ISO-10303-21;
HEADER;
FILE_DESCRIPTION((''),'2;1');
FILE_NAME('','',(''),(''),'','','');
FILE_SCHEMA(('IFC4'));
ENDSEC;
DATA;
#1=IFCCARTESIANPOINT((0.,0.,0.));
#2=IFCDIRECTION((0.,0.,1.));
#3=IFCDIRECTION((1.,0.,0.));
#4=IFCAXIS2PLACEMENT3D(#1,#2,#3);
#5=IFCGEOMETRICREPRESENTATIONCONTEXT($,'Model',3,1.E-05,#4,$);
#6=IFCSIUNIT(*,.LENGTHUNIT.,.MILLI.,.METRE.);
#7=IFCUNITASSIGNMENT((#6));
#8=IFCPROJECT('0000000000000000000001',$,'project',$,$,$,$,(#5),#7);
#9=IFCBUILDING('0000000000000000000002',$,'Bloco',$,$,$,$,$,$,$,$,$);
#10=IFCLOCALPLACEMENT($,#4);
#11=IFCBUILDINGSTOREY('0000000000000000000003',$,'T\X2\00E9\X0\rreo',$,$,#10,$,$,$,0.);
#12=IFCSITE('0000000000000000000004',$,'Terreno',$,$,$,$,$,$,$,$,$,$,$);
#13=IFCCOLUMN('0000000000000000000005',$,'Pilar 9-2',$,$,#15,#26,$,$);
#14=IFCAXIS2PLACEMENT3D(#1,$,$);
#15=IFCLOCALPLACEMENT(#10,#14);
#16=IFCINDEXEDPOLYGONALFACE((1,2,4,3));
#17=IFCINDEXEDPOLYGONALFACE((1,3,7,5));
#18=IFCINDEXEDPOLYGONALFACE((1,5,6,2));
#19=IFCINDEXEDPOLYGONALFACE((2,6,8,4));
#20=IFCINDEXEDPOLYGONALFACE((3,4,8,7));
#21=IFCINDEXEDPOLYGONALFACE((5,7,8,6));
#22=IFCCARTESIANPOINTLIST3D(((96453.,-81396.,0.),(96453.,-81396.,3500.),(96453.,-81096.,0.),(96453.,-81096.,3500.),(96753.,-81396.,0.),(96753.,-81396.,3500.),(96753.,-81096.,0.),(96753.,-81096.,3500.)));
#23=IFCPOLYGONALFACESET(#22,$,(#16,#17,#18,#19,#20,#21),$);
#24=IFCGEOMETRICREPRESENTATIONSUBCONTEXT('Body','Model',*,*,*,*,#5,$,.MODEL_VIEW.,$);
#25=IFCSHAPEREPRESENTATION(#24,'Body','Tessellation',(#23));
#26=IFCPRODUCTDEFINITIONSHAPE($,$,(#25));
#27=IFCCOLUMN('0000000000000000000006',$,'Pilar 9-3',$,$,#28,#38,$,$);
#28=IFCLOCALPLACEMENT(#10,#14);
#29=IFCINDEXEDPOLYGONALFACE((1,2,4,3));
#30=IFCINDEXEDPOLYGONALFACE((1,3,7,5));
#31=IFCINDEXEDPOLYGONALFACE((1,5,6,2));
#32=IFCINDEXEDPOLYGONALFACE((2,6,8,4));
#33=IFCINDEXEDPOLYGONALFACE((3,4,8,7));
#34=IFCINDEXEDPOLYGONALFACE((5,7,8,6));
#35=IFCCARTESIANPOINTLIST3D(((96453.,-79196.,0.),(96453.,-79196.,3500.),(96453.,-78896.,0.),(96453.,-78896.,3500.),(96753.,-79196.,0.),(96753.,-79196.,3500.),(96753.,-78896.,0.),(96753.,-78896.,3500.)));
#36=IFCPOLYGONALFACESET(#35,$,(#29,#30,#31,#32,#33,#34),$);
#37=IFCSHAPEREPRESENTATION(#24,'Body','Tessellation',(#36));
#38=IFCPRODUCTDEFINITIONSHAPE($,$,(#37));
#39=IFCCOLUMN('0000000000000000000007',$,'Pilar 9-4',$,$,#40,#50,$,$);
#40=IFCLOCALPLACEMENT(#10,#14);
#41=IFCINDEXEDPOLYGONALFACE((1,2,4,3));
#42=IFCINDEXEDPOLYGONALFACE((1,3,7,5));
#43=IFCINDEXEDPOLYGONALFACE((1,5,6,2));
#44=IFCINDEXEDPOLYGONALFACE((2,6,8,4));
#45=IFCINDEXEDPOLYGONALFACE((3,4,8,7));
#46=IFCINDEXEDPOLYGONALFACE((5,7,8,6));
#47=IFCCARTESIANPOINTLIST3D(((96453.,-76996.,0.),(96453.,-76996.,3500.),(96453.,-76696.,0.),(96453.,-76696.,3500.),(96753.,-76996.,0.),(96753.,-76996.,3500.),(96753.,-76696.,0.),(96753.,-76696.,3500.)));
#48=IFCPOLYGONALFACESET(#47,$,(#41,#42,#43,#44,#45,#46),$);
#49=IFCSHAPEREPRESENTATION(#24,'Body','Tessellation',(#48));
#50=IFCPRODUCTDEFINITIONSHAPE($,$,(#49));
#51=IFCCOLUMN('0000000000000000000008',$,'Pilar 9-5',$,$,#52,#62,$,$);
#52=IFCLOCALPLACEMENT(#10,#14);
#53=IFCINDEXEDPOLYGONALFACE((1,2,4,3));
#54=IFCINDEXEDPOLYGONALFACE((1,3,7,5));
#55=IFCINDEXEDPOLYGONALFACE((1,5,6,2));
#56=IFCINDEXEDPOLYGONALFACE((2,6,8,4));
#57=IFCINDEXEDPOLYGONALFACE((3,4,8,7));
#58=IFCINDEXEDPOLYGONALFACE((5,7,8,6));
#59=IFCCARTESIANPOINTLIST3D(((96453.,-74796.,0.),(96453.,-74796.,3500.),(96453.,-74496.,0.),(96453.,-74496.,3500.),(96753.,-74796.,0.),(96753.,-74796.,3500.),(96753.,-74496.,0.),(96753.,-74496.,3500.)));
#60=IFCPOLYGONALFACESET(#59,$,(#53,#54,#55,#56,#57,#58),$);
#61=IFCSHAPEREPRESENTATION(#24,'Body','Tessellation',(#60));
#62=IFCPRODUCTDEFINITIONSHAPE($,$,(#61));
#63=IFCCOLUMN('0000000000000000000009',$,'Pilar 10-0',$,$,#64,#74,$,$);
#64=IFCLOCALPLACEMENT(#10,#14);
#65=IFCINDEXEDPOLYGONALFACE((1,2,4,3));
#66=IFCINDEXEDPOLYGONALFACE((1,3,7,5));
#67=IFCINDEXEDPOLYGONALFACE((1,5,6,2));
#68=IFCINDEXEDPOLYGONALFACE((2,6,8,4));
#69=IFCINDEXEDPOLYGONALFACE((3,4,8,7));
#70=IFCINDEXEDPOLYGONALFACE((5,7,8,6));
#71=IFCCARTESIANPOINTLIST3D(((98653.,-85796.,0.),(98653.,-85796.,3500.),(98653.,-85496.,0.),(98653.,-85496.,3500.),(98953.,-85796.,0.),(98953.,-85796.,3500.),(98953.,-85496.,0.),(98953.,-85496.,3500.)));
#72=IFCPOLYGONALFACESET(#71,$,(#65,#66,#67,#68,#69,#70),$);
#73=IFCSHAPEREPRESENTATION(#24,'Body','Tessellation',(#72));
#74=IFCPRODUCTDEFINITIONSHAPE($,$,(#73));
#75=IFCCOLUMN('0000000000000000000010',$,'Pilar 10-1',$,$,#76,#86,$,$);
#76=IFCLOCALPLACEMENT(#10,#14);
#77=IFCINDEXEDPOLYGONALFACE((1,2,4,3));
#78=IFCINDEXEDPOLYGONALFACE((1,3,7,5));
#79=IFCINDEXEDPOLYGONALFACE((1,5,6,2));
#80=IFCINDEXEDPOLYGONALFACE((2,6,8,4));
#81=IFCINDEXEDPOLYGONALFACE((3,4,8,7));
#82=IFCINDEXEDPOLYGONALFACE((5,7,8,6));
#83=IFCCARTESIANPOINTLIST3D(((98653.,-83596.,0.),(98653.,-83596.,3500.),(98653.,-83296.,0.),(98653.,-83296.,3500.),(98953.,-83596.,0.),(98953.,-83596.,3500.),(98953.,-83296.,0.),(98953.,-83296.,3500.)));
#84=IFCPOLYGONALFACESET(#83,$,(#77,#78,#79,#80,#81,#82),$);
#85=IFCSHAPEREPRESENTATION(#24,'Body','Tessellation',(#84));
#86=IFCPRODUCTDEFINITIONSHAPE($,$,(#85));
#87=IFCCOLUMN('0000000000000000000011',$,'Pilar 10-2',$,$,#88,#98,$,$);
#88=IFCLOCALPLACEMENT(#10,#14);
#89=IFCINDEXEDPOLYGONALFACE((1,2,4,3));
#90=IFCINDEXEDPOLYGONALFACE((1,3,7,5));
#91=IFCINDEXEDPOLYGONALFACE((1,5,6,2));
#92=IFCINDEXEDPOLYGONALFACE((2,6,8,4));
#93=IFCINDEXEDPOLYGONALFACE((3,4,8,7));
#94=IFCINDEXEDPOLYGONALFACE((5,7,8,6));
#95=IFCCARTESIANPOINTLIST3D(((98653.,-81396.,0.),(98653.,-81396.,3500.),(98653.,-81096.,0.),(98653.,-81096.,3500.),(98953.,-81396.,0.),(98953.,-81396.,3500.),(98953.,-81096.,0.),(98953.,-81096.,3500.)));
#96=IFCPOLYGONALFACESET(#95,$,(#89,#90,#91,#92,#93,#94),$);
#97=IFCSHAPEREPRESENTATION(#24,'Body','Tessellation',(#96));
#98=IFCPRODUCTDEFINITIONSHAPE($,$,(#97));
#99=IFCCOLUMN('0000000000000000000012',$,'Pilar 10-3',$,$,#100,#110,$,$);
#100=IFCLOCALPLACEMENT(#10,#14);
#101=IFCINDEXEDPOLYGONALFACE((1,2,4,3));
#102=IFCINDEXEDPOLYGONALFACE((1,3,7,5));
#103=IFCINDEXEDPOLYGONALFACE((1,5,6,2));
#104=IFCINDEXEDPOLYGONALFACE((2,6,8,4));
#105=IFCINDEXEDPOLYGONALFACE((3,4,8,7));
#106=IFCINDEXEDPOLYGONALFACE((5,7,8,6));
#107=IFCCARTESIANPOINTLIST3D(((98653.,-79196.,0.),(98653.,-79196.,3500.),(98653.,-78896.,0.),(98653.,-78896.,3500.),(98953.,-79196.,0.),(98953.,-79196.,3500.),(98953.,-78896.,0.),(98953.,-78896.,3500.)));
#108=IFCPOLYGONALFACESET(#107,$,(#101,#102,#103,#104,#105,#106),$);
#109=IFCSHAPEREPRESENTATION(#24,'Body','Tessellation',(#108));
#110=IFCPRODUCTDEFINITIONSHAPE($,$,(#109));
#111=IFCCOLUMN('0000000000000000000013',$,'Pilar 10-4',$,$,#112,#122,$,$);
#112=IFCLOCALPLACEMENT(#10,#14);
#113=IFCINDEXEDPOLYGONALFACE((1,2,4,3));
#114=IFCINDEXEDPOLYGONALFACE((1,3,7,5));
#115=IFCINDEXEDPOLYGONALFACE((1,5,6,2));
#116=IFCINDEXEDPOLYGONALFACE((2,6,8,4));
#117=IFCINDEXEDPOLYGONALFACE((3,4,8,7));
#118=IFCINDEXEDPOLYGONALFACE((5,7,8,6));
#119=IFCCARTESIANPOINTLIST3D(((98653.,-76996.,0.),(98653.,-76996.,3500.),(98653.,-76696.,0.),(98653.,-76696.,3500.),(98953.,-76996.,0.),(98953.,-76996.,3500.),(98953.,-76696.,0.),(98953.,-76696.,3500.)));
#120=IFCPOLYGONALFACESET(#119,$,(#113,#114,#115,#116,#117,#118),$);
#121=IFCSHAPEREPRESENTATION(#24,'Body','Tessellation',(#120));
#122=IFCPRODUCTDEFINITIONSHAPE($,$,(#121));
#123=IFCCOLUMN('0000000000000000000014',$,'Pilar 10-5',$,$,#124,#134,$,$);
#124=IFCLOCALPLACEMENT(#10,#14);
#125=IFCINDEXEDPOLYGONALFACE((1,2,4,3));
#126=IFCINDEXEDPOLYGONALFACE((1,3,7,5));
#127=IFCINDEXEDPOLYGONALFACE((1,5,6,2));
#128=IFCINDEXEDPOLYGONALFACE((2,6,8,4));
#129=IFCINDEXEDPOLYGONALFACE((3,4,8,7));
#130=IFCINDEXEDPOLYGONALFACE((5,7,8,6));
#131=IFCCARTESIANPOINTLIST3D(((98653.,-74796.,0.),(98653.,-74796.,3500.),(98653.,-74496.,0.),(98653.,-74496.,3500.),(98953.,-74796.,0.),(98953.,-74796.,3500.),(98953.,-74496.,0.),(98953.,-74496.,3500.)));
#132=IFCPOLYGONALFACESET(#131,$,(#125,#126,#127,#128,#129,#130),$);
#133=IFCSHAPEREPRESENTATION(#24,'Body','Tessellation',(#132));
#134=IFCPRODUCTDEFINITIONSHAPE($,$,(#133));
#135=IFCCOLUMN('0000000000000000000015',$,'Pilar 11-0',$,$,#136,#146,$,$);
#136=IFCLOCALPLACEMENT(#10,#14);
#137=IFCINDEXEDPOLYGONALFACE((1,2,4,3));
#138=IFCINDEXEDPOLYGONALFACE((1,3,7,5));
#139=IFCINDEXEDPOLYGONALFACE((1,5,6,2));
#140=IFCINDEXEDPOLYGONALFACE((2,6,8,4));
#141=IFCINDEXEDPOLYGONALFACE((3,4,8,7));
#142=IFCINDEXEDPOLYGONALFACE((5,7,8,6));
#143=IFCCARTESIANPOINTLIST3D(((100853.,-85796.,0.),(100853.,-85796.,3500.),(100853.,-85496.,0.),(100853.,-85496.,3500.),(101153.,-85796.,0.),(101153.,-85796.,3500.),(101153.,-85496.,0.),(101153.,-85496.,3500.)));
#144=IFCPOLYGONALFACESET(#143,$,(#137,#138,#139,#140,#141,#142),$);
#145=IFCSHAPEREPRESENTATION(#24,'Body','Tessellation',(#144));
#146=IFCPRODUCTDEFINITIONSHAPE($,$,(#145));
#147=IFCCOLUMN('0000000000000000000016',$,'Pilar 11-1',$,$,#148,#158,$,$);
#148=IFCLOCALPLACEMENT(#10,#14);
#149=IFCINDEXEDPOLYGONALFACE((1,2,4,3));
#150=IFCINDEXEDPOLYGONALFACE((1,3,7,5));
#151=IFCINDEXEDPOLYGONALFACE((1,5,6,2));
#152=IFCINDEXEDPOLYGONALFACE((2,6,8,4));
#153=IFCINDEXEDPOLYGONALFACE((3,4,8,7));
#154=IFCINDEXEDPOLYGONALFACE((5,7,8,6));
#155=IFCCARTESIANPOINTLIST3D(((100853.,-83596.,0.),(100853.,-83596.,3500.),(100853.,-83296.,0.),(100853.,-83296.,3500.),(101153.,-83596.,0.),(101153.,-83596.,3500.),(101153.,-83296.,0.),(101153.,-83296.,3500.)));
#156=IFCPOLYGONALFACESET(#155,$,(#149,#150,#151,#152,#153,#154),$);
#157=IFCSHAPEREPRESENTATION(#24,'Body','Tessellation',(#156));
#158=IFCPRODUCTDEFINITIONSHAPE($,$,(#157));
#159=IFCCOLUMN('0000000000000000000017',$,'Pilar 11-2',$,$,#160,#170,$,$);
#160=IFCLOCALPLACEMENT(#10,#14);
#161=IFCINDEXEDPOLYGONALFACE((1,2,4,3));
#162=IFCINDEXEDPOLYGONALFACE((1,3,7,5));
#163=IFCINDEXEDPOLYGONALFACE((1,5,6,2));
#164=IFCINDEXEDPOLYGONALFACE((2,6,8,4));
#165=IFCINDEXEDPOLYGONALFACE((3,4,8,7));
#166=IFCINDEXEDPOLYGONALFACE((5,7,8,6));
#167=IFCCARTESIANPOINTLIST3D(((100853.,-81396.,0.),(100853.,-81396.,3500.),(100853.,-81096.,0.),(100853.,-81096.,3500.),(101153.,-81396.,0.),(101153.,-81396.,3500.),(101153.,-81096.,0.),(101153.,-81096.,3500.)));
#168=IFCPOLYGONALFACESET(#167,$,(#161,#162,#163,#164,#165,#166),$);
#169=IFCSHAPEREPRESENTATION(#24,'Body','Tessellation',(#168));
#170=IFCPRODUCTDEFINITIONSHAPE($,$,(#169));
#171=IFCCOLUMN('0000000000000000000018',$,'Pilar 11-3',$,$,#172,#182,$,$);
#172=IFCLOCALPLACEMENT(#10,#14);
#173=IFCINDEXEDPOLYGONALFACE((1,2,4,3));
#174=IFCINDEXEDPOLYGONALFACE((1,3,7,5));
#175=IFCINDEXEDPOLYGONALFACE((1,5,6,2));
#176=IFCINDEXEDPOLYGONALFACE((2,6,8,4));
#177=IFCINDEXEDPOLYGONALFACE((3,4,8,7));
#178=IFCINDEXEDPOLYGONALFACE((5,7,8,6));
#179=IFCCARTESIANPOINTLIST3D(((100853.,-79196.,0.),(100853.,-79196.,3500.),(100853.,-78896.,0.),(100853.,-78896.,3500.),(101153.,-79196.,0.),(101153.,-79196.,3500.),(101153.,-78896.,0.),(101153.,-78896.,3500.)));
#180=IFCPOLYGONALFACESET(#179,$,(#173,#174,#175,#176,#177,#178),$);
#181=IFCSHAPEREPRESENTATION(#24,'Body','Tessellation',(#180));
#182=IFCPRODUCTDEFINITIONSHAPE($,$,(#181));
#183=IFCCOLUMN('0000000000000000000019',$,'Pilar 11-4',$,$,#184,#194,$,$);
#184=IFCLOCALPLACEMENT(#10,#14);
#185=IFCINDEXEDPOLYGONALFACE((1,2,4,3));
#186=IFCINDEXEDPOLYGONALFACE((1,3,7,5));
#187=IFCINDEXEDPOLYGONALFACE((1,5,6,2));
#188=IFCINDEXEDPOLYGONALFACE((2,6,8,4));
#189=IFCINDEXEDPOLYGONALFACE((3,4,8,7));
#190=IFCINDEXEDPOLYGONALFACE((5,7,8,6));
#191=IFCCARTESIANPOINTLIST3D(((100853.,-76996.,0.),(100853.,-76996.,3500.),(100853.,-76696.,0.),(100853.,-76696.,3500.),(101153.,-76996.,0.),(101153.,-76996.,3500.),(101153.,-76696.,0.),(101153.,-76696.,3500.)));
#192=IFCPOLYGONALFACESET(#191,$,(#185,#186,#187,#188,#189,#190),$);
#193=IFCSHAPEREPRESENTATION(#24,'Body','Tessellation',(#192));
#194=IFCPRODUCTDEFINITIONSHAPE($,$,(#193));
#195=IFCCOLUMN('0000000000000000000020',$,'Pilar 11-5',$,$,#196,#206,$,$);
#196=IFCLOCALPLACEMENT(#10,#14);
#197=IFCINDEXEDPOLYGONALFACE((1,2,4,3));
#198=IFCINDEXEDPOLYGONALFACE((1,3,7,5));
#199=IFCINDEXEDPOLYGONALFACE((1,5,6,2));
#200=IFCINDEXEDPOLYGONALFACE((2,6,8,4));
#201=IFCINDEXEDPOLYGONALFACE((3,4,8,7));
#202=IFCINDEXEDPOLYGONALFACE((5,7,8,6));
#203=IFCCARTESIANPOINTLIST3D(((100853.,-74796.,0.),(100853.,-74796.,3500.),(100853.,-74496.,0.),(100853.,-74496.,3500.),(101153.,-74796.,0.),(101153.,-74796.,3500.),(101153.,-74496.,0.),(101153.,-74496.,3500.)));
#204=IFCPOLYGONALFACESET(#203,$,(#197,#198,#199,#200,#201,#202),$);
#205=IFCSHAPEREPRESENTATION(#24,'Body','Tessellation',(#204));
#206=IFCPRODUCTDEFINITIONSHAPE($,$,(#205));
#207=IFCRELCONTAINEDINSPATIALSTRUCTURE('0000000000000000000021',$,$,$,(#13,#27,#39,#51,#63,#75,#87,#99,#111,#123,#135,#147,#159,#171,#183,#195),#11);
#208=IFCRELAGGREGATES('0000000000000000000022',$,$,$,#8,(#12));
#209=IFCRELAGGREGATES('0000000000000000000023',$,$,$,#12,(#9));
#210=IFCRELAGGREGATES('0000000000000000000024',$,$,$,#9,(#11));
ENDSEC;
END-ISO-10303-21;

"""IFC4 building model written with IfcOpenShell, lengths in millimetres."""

from ifc_helpers import new_model, si_unit, origin, origin_with_axes, place, context, subcontext, project, spatial, polyline, outline, extrude, element, save


model = new_model("IFC4")

# Units and contexts
model_context = context("Model", 3, precision=1e-05, world=origin_with_axes())
body_context = subcontext(model_context, "Body", "Model", "MODEL_VIEW")
ifc_project = project(units=[si_unit("LENGTHUNIT", "METRE", prefix="MILLI")], contexts=[model_context])

# Site, building, storey
site = spatial("IfcSite", under=ifc_project, Name="Terreno")
building = spatial("IfcBuilding", under=site, Name="Bloco")
storey_placement = place(None, origin_with_axes())
storey = spatial("IfcBuildingStorey", under=building, at=storey_placement, Name="Térreo", Elevation=0.0)

# Columns
column_1_placement = place(storey_placement, origin_with_axes())
element("IfcColumn", 1, at=column_1_placement, inside=storey, Name="Pilar 9-2", context=body_context, shape_type="SweptSolid", body=[
    extrude(outline(polyline([(96453.0, -81396.0), (96753.0, -81396.0), (96753.0, -81096.0), (96453.0, -81096.0), (96453.0, -81396.0)])), origin(), (0.0, 0.0, 1.0), 3500.0),
])
column_2_placement = place(storey_placement, origin_with_axes())
element("IfcColumn", 2, at=column_2_placement, inside=storey, Name="Pilar 9-3", context=body_context, shape_type="SweptSolid", body=[
    extrude(outline(polyline([(96453.0, -79196.0), (96753.0, -79196.0), (96753.0, -78896.0), (96453.0, -78896.0), (96453.0, -79196.0)])), origin(), (0.0, 0.0, 1.0), 3500.0),
])
column_3_placement = place(storey_placement, origin_with_axes())
element("IfcColumn", 3, at=column_3_placement, inside=storey, Name="Pilar 9-4", context=body_context, shape_type="SweptSolid", body=[
    extrude(outline(polyline([(96453.0, -76996.0), (96753.0, -76996.0), (96753.0, -76696.0), (96453.0, -76696.0), (96453.0, -76996.0)])), origin(), (0.0, 0.0, 1.0), 3500.0),
])
column_4_placement = place(storey_placement, origin_with_axes())
element("IfcColumn", 4, at=column_4_placement, inside=storey, Name="Pilar 9-5", context=body_context, shape_type="SweptSolid", body=[
    extrude(outline(polyline([(96453.0, -74796.0), (96753.0, -74796.0), (96753.0, -74496.0), (96453.0, -74496.0), (96453.0, -74796.0)])), origin(), (0.0, 0.0, 1.0), 3500.0),
])
column_5_placement = place(storey_placement, origin_with_axes())
element("IfcColumn", 5, at=column_5_placement, inside=storey, Name="Pilar 10-0", context=body_context, shape_type="SweptSolid", body=[
    extrude(outline(polyline([(98653.0, -85796.0), (98953.0, -85796.0), (98953.0, -85496.0), (98653.0, -85496.0), (98653.0, -85796.0)])), origin(), (0.0, 0.0, 1.0), 3500.0),
])
column_6_placement = place(storey_placement, origin_with_axes())
element("IfcColumn", 6, at=column_6_placement, inside=storey, Name="Pilar 10-1", context=body_context, shape_type="SweptSolid", body=[
    extrude(outline(polyline([(98653.0, -83596.0), (98953.0, -83596.0), (98953.0, -83296.0), (98653.0, -83296.0), (98653.0, -83596.0)])), origin(), (0.0, 0.0, 1.0), 3500.0),
])
column_7_placement = place(storey_placement, origin_with_axes())
element("IfcColumn", 7, at=column_7_placement, inside=storey, Name="Pilar 10-2", context=body_context, shape_type="SweptSolid", body=[
    extrude(outline(polyline([(98653.0, -81396.0), (98953.0, -81396.0), (98953.0, -81096.0), (98653.0, -81096.0), (98653.0, -81396.0)])), origin(), (0.0, 0.0, 1.0), 3500.0),
])
column_8_placement = place(storey_placement, origin_with_axes())
element("IfcColumn", 8, at=column_8_placement, inside=storey, Name="Pilar 10-3", context=body_context, shape_type="SweptSolid", body=[
    extrude(outline(polyline([(98653.0, -79196.0), (98953.0, -79196.0), (98953.0, -78896.0), (98653.0, -78896.0), (98653.0, -79196.0)])), origin(), (0.0, 0.0, 1.0), 3500.0),
])
column_9_placement = place(storey_placement, origin_with_axes())
element("IfcColumn", 9, at=column_9_placement, inside=storey, Name="Pilar 10-4", context=body_context, shape_type="SweptSolid", body=[
    extrude(outline(polyline([(98653.0, -76996.0), (98953.0, -76996.0), (98953.0, -76696.0), (98653.0, -76696.0), (98653.0, -76996.0)])), origin(), (0.0, 0.0, 1.0), 3500.0),
])
column_10_placement = place(storey_placement, origin_with_axes())
element("IfcColumn", 10, at=column_10_placement, inside=storey, Name="Pilar 10-5", context=body_context, shape_type="SweptSolid", body=[
    extrude(outline(polyline([(98653.0, -74796.0), (98953.0, -74796.0), (98953.0, -74496.0), (98653.0, -74496.0), (98653.0, -74796.0)])), origin(), (0.0, 0.0, 1.0), 3500.0),
])
column_11_placement = place(storey_placement, origin_with_axes())
element("IfcColumn", 11, at=column_11_placement, inside=storey, Name="Pilar 11-0", context=body_context, shape_type="SweptSolid", body=[
    extrude(outline(polyline([(100853.0, -85796.0), (101153.0, -85796.0), (101153.0, -85496.0), (100853.0, -85496.0), (100853.0, -85796.0)])), origin(), (0.0, 0.0, 1.0), 3500.0),
])
column_12_placement = place(storey_placement, origin_with_axes())
element("IfcColumn", 12, at=column_12_placement, inside=storey, Name="Pilar 11-1", context=body_context, shape_type="SweptSolid", body=[
    extrude(outline(polyline([(100853.0, -83596.0), (101153.0, -83596.0), (101153.0, -83296.0), (100853.0, -83296.0), (100853.0, -83596.0)])), origin(), (0.0, 0.0, 1.0), 3500.0),
])
column_13_placement = place(storey_placement, origin_with_axes())
element("IfcColumn", 13, at=column_13_placement, inside=storey, Name="Pilar 11-2", context=body_context, shape_type="SweptSolid", body=[
    extrude(outline(polyline([(100853.0, -81396.0), (101153.0, -81396.0), (101153.0, -81096.0), (100853.0, -81096.0), (100853.0, -81396.0)])), origin(), (0.0, 0.0, 1.0), 3500.0),
])
column_14_placement = place(storey_placement, origin_with_axes())
element("IfcColumn", 14, at=column_14_placement, inside=storey, Name="Pilar 11-3", context=body_context, shape_type="SweptSolid", body=[
    extrude(outline(polyline([(100853.0, -79196.0), (101153.0, -79196.0), (101153.0, -78896.0), (100853.0, -78896.0), (100853.0, -79196.0)])), origin(), (0.0, 0.0, 1.0), 3500.0),
])
column_15_placement = place(storey_placement, origin_with_axes())
element("IfcColumn", 15, at=column_15_placement, inside=storey, Name="Pilar 11-4", context=body_context, shape_type="SweptSolid", body=[
    extrude(outline(polyline([(100853.0, -76996.0), (101153.0, -76996.0), (101153.0, -76696.0), (100853.0, -76696.0), (100853.0, -76996.0)])), origin(), (0.0, 0.0, 1.0), 3500.0),
])
column_16_placement = place(storey_placement, origin_with_axes())
element("IfcColumn", 16, at=column_16_placement, inside=storey, Name="Pilar 11-5", context=body_context, shape_type="SweptSolid", body=[
    extrude(outline(polyline([(100853.0, -74796.0), (101153.0, -74796.0), (101153.0, -74496.0), (100853.0, -74496.0), (100853.0, -74796.0)])), origin(), (0.0, 0.0, 1.0), 3500.0),
])

save(model, "model.ifc")
